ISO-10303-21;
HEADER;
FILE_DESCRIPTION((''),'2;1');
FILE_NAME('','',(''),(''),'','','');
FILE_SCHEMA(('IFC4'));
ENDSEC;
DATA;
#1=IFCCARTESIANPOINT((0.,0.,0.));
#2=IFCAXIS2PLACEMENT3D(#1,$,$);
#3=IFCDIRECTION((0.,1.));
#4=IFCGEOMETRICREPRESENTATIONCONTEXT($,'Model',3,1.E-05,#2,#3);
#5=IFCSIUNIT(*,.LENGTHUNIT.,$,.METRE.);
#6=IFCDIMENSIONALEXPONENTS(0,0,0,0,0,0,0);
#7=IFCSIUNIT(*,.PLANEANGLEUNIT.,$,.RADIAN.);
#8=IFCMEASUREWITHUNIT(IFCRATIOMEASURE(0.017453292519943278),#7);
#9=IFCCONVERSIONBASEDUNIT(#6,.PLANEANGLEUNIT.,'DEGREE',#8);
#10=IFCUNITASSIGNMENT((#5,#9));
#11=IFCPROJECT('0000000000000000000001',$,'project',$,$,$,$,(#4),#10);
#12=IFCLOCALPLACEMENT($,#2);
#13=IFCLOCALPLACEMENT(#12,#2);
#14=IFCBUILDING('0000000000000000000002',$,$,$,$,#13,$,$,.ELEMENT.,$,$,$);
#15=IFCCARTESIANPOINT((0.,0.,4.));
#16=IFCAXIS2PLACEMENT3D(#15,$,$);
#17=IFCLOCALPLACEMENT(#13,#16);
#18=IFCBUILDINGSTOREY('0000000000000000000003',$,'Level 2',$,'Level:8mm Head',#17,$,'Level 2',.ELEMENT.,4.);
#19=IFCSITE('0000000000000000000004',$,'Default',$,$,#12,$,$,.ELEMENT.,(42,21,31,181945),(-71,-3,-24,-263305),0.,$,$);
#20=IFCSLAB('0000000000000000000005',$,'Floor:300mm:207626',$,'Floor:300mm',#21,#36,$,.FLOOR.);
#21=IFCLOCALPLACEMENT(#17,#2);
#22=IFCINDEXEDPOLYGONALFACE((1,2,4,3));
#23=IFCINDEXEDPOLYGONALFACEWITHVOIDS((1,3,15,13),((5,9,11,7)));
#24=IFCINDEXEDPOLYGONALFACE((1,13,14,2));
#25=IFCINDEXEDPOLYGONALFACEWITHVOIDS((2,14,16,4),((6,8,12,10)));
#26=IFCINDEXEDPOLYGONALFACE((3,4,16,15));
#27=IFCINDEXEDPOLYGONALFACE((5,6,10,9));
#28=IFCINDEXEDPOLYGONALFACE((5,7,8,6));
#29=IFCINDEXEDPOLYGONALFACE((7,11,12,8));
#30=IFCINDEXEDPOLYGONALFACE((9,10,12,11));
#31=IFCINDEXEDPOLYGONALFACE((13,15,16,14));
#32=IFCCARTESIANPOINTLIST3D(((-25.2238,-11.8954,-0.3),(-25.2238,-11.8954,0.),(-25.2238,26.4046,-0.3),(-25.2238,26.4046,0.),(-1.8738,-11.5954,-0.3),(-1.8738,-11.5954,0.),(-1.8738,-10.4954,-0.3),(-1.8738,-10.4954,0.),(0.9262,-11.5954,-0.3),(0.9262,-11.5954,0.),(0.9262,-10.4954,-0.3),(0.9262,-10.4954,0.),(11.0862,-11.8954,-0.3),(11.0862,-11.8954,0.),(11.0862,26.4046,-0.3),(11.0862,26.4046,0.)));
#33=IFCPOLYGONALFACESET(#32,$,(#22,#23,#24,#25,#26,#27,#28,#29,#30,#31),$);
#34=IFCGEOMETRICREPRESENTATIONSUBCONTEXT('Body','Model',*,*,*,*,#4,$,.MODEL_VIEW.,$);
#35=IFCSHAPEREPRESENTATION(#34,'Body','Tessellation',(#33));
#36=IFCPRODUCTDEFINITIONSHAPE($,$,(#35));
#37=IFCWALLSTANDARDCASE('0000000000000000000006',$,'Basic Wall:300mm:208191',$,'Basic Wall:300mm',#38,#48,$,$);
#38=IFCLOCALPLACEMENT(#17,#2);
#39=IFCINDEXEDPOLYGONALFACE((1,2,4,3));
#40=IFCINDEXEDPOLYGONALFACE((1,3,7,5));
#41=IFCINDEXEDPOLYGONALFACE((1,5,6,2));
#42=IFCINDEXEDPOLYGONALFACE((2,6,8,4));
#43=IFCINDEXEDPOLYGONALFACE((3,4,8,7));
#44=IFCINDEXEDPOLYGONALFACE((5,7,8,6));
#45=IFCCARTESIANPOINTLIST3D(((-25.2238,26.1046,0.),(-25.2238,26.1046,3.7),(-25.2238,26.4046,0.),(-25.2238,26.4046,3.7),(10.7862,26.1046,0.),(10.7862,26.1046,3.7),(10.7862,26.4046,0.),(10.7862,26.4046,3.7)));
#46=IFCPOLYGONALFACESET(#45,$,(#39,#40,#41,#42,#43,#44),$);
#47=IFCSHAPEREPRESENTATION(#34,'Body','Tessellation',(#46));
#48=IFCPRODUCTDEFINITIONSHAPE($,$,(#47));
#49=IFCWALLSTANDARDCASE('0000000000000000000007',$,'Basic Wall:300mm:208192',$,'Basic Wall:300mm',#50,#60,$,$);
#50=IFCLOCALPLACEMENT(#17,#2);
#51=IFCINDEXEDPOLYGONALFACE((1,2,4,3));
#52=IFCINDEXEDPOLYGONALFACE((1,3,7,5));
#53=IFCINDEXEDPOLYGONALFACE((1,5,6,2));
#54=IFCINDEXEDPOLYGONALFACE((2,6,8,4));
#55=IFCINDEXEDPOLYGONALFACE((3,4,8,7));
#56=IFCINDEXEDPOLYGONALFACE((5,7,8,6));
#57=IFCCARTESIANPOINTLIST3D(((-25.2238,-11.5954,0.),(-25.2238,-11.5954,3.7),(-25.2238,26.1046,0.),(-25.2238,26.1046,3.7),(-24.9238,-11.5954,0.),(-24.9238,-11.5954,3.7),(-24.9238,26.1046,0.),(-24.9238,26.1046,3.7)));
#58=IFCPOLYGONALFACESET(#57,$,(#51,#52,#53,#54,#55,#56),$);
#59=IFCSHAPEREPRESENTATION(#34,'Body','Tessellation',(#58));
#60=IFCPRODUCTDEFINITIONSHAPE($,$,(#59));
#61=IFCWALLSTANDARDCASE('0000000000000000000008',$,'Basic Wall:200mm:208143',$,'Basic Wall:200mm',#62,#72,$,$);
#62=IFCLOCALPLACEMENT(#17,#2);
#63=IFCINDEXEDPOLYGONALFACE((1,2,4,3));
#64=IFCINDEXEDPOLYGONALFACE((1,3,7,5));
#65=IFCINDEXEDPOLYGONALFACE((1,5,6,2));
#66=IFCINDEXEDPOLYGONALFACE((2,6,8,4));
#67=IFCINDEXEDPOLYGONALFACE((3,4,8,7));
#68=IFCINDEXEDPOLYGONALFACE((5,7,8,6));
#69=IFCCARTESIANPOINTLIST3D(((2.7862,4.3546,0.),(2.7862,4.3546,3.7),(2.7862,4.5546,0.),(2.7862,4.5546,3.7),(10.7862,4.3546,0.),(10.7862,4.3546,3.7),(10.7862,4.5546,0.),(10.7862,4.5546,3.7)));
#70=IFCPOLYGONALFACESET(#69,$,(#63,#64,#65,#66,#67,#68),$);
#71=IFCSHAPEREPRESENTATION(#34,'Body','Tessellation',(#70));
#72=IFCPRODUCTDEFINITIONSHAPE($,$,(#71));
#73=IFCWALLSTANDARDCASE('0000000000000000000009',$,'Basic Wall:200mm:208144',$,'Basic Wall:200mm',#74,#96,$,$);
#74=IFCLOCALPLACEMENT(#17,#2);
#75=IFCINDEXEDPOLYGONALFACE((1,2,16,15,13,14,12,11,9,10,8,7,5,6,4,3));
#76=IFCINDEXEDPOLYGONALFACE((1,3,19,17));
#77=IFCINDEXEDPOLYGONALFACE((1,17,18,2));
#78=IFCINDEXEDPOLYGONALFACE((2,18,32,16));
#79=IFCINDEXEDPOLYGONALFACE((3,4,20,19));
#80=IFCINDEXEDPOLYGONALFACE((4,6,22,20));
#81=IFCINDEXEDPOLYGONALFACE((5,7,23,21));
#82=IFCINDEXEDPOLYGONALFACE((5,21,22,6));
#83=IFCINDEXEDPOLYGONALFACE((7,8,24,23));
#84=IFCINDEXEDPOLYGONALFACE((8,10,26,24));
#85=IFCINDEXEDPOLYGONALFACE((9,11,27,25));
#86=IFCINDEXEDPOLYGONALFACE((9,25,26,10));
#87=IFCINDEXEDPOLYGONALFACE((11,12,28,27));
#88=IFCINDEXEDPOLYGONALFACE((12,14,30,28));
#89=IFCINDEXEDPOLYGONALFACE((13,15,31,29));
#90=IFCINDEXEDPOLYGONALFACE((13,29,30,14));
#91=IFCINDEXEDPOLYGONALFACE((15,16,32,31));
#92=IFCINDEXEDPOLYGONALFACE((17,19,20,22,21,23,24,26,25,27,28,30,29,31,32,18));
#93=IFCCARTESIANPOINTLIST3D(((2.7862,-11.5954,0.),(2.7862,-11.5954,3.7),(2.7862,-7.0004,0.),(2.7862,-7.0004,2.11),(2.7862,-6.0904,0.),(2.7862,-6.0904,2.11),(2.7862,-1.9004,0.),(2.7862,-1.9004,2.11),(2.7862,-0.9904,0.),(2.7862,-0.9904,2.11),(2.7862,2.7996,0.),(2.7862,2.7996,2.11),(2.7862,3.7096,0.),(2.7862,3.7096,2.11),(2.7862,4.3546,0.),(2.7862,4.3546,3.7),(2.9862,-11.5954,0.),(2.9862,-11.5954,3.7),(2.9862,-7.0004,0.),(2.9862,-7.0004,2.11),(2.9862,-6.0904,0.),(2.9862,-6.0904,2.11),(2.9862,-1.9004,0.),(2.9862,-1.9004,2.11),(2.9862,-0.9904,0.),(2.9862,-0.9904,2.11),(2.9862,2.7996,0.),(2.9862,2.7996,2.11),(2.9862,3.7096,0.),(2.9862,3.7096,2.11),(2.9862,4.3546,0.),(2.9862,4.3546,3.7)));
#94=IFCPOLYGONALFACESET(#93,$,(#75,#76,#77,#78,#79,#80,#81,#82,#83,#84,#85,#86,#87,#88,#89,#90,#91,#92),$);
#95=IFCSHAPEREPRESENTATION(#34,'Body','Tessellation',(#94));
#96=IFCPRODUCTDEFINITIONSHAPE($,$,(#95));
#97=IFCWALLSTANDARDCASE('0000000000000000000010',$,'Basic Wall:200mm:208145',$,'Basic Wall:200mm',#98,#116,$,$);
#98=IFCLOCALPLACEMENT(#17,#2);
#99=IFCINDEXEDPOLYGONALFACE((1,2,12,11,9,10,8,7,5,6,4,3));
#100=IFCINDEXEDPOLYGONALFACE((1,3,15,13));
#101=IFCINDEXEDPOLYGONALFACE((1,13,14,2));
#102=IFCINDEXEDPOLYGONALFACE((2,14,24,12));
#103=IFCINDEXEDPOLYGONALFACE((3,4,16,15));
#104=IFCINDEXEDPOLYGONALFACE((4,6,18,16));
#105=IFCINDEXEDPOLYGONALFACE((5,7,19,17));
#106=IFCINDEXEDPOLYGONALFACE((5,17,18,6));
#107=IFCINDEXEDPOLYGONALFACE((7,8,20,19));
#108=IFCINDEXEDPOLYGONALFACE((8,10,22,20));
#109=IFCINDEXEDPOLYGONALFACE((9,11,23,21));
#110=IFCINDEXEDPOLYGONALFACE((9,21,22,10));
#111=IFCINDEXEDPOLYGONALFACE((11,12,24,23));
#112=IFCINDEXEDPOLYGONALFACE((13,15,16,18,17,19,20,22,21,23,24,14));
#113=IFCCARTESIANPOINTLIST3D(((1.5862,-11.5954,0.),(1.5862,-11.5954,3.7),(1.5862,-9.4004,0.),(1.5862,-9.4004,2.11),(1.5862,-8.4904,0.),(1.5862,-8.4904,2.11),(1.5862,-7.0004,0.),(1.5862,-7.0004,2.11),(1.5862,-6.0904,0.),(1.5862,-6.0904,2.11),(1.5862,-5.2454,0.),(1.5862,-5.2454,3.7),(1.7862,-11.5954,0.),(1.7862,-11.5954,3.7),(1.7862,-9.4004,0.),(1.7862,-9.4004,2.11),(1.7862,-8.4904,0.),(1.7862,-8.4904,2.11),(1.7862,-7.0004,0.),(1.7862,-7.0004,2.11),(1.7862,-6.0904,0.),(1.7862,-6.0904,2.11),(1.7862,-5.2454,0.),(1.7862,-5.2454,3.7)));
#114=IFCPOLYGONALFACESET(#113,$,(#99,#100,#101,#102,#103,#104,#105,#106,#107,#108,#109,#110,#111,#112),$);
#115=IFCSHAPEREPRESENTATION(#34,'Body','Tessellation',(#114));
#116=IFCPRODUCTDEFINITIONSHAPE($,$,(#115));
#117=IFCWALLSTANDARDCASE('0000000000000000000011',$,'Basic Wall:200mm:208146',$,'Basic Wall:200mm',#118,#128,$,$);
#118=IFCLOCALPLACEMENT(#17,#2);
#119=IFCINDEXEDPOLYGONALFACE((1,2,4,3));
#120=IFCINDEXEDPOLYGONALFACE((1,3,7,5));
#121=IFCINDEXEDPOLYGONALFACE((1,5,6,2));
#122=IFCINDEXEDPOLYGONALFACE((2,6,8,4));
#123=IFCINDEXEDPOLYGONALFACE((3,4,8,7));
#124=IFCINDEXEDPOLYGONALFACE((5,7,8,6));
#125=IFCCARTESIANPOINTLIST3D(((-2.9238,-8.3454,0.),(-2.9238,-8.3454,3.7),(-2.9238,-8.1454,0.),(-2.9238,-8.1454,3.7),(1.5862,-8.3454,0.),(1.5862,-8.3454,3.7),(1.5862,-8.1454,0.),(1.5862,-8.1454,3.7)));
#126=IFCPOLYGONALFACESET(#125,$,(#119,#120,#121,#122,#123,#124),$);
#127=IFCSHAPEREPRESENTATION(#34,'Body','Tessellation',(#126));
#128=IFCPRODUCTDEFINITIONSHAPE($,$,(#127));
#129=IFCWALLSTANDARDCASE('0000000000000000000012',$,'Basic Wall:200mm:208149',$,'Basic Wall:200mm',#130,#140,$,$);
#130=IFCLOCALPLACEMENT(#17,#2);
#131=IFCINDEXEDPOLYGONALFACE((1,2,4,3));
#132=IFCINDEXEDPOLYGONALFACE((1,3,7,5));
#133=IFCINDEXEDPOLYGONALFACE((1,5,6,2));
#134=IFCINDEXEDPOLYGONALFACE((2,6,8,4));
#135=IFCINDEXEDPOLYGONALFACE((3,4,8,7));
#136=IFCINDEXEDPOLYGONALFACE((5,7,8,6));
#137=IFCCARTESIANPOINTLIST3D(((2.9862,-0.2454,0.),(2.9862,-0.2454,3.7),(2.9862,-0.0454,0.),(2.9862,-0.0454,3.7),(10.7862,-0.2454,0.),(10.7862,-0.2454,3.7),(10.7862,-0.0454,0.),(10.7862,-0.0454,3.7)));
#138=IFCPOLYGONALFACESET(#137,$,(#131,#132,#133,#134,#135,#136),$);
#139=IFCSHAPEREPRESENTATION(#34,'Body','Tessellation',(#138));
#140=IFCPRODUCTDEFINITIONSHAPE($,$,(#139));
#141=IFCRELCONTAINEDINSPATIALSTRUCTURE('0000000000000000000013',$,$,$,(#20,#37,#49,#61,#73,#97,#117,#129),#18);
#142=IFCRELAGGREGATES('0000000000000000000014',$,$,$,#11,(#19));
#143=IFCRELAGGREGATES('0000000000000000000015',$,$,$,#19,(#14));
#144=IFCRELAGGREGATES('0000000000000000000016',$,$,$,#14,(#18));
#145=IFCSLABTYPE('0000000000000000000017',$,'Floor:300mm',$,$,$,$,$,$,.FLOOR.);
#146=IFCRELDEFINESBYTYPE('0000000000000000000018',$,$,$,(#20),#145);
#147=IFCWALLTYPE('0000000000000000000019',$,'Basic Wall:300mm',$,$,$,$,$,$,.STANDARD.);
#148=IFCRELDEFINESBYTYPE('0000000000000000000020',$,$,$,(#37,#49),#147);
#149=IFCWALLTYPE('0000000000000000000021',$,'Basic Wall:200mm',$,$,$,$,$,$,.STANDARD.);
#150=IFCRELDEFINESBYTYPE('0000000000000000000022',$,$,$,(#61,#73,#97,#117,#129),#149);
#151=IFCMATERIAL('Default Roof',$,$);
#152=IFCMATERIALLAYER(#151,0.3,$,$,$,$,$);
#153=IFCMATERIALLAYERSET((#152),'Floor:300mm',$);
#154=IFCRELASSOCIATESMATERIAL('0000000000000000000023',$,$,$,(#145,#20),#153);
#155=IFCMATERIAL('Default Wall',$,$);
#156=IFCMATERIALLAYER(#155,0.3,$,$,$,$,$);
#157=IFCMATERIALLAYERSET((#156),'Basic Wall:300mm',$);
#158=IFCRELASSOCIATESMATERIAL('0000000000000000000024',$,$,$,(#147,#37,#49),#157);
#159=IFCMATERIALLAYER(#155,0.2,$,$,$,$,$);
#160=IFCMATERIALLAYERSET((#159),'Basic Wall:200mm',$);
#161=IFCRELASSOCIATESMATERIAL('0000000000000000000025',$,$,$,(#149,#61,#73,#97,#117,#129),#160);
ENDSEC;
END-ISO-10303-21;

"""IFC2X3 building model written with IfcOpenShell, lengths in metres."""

from ifc_helpers import new_model, entity, si_unit, converted_unit, direction, frame, frame_2d, origin, origin_2d_with_axis, place, context, subcontext, project, spatial, polyline, rectangle, extrude, clip, bounded_halfspace, material, layer, layer_set, layer_usage, type_object, element, save


model = new_model("IFC2X3")

# Units and contexts
model_context = context("Model", 3, precision=1e-05, world=origin(), true_north=direction((0.0, 1.0)))
body_context = subcontext(model_context, "Body", "Model", "MODEL_VIEW")
ifc_project = project(units=[si_unit("LENGTHUNIT", "METRE"), converted_unit("PLANEANGLEUNIT", "DEGREE", entity("IfcRatioMeasure", 0.017453292519943278), si_unit("PLANEANGLEUNIT", "RADIAN"), dimensions=[0, 0, 0, 0, 0, 0, 0])], contexts=[model_context])

# Site, building, storey
site_placement = place(None, origin())
site = spatial("IfcSite", under=ifc_project, at=site_placement, Name="Default", CompositionType="ELEMENT", RefLatitude=(42, 21, 31, 181945), RefLongitude=(-71, -3, -24, -263305), RefElevation=0.0)
building_placement = place(site_placement, origin())
building = spatial("IfcBuilding", under=site, at=building_placement, CompositionType="ELEMENT")
storey_placement = place(building_placement, frame((0.0, 0.0, 4.0)))
storey = spatial("IfcBuildingStorey", under=building, at=storey_placement, Name="Level 2", ObjectType="Level:8mm Head", LongName="Level 2", CompositionType="ELEMENT", Elevation=4.0)

# Slab, opening
ifc_material_1 = material(Name="Default Roof")
ifc_layer_1 = layer(ifc_material_1, 0.3)
ifc_layer_set_1 = layer_set([ifc_layer_1], Name="Floor:300mm")
ifc_layer_usage_1 = layer_usage(ifc_layer_set_1, "AXIS3", "POSITIVE", 0.0)
slab_type = type_object("IfcSlabType", Name="Floor:300mm", PredefinedType="FLOOR", material=ifc_layer_set_1)
slab_placement = place(storey_placement, frame((-25.2238, -11.8954, -0.3)))
slab = element("IfcSlab", 1, at=slab_placement, inside=storey, type_object=slab_type, material=ifc_layer_usage_1, Name="Floor:300mm:207626", ObjectType="Floor:300mm", PredefinedType="FLOOR", context=body_context, shape_type="SweptSolid", body=[
    extrude(rectangle(XDim=38.3, YDim=36.31, at=frame_2d((0.0, 0.0), x_axis=(0.0, -1.0))), frame((18.155, 19.15, 0.3), z_axis=(0.0, 0.0, -1.0), x_axis=(-1.0, 0.0, 0.0)), (0.0, 0.0, 1.0), 0.3),
])
opening_1_placement = place(slab_placement, frame((24.75, 0.85, 0.3)))
element("IfcOpeningElement", 2, at=opening_1_placement, cuts=slab, ObjectType="Opening", context=body_context, shape_type="SweptSolid", body=[
    extrude(rectangle(XDim=1.1, YDim=2.8, at=origin_2d_with_axis()), frame((0.0, 0.0, 0.0), z_axis=(0.0, 0.0, 1.0), x_axis=(0.0, -1.0, 0.0)), (0.0, 0.0, -1.0), 0.3),
])

# Walls
ifc_material_2 = material(Name="Default Wall")
ifc_layer_2 = layer(ifc_material_2, 0.3)
ifc_layer_set_2 = layer_set([ifc_layer_2], Name="Basic Wall:300mm")
wall_type_1 = type_object("IfcWallType", Name="Basic Wall:300mm", PredefinedType="STANDARD", material=ifc_layer_set_2)
ifc_layer_usage_2 = layer_usage(ifc_layer_set_2, "AXIS2", "NEGATIVE", 0.15)
wall_1_placement = place(storey_placement, frame((-25.2238, 26.2546, 0.0)))
element("IfcWallStandardCase", 3, at=wall_1_placement, inside=storey, type_object=wall_type_1, material=ifc_layer_usage_2, Name="Basic Wall:300mm:208191", ObjectType="Basic Wall:300mm", context=body_context, shape_type="Clipping", body=[
    clip(extrude(rectangle(XDim=36.01, YDim=0.3, at=frame_2d((18.005, 0.0), x_axis=(-1.0, 0.0))), origin(), (0.0, 0.0, 1.0), 3.7), bounded_halfspace(frame((0.0, -0.15, 3.7), z_axis=(0.0, 0.0, -1.0), x_axis=(0.0, -1.0, 0.0)), True, frame((0.0, -0.15, 3.7), z_axis=(0.0, 0.0, -1.0), x_axis=(0.0, -1.0, 0.0)), polyline([(0.0, 0.0), (-0.3, 0.0), (-0.3, -36.01), (0.0, -36.01), (0.0, -0.3), (0.0, 0.0)]))),
])
ifc_layer_usage_3 = layer_usage(ifc_layer_set_2, "AXIS2", "NEGATIVE", 0.15)
wall_2_placement = place(storey_placement, frame((-25.0738, -11.5954, 0.0), z_axis=(0.0, 0.0, 1.0), x_axis=(0.0, 1.0, 0.0)))
element("IfcWallStandardCase", 4, at=wall_2_placement, inside=storey, type_object=wall_type_1, material=ifc_layer_usage_3, Name="Basic Wall:300mm:208192", ObjectType="Basic Wall:300mm", context=body_context, shape_type="Clipping", body=[
    clip(extrude(rectangle(XDim=37.7, YDim=0.3, at=frame_2d((18.85, 0.0), x_axis=(-1.0, 0.0))), origin(), (0.0, 0.0, 1.0), 3.7), bounded_halfspace(frame((0.0, -0.15, 3.7), z_axis=(0.0, 0.0, -1.0), x_axis=(-1.0, 0.0, 0.0)), True, frame((0.0, -0.15, 3.7), z_axis=(0.0, 0.0, -1.0), x_axis=(-1.0, 0.0, 0.0)), polyline([(0.0, 0.0), (0.0, 0.3), (-37.7, 0.3), (-37.7, 0.0), (-6.35, 0.0), (-6.15, 0.0), (0.0, 0.0)]))),
])
ifc_layer_3 = layer(ifc_material_2, 0.2)
ifc_layer_set_3 = layer_set([ifc_layer_3], Name="Basic Wall:200mm")
ifc_layer_usage_4 = layer_usage(ifc_layer_set_3, "AXIS2", "NEGATIVE", 0.1)
wall_type_2 = type_object("IfcWallType", Name="Basic Wall:200mm", PredefinedType="STANDARD", material=ifc_layer_set_3)
wall_3_placement = place(storey_placement, frame((10.7862, 4.4546, 0.0), z_axis=(0.0, 0.0, 1.0), x_axis=(-1.0, 0.0, 0.0)))
element("IfcWallStandardCase", 5, at=wall_3_placement, inside=storey, type_object=wall_type_2, material=ifc_layer_usage_4, Name="Basic Wall:200mm:208143", ObjectType="Basic Wall:200mm", context=body_context, shape_type="Clipping", body=[
    clip(extrude(rectangle(XDim=8.0, YDim=0.2, at=frame_2d((4.0, 0.0), x_axis=(-1.0, 0.0))), origin(), (0.0, 0.0, 1.0), 3.7), bounded_halfspace(frame((0.0, -0.1, 3.7), z_axis=(0.0, 0.0, -1.0), x_axis=(0.0, 1.0, 0.0)), True, frame((0.0, -0.1, 3.7), z_axis=(0.0, 0.0, -1.0), x_axis=(0.0, 1.0, 0.0)), polyline([(0.0, 0.0), (0.2, 0.0), (0.2, 7.8), (0.2, 8.0), (0.0, 8.0), (0.0, 0.0)]))),
])

# Walls, openings
ifc_layer_usage_5 = layer_usage(ifc_layer_set_3, "AXIS2", "NEGATIVE", 0.1)
wall_4_placement = place(storey_placement, frame((2.8862, 4.3546, 0.0), z_axis=(0.0, 0.0, 1.0), x_axis=(0.0, -1.0, 0.0)))
wall_4 = element("IfcWallStandardCase", 6, at=wall_4_placement, inside=storey, type_object=wall_type_2, material=ifc_layer_usage_5, Name="Basic Wall:200mm:208144", ObjectType="Basic Wall:200mm", context=body_context, shape_type="Clipping", body=[
    clip(extrude(rectangle(XDim=15.95, YDim=0.2, at=frame_2d((7.975, 0.0), x_axis=(-1.0, 0.0))), origin(), (0.0, 0.0, 1.0), 3.7), bounded_halfspace(frame((0.0, -0.1, 3.7), z_axis=(0.0, 0.0, -1.0), x_axis=(1.0, 0.0, 0.0)), True, frame((0.0, -0.1, 3.7), z_axis=(0.0, 0.0, -1.0), x_axis=(1.0, 0.0, 0.0)), polyline([(0.0, 0.0), (0.0, -0.2), (4.4, -0.2), (4.6, -0.2), (9.8, -0.2), (10.0, -0.2), (15.95, -0.2), (15.95, 0.0), (0.0, 0.0)]))),
])
opening_2_placement = place(wall_4_placement, frame((0.645, -0.1, 0.0)))
element("IfcOpeningElement", 7, at=opening_2_placement, cuts=wall_4, ObjectType="Opening", context=body_context, shape_type="SweptSolid", body=[
    extrude(rectangle(XDim=2.11, YDim=0.91, at=frame_2d((1.055, 0.455), x_axis=(1.0, 0.0))), frame((0.0, 0.0, 0.0), z_axis=(0.0, 1.0, 0.0), x_axis=(0.0, 0.0, 1.0)), (0.0, 0.0, 1.0), 0.2),
])
opening_3_placement = place(wall_4_placement, frame((5.345, -0.1, 0.0)))
element("IfcOpeningElement", 8, at=opening_3_placement, cuts=wall_4, ObjectType="Opening", context=body_context, shape_type="SweptSolid", body=[
    extrude(rectangle(XDim=2.11, YDim=0.91, at=frame_2d((1.055, 0.455), x_axis=(1.0, 0.0))), frame((0.0, 0.0, 0.0), z_axis=(0.0, 1.0, 0.0), x_axis=(0.0, 0.0, 1.0)), (0.0, 0.0, 1.0), 0.2),
])
opening_4_placement = place(wall_4_placement, frame((10.445, -0.1, 0.0)))
element("IfcOpeningElement", 9, at=opening_4_placement, cuts=wall_4, ObjectType="Opening", context=body_context, shape_type="SweptSolid", body=[
    extrude(rectangle(XDim=2.11, YDim=0.91, at=frame_2d((1.055, 0.455), x_axis=(1.0, 0.0))), frame((0.0, 0.0, 0.0), z_axis=(0.0, 1.0, 0.0), x_axis=(0.0, 0.0, 1.0)), (0.0, 0.0, 1.0), 0.2),
])
ifc_layer_usage_6 = layer_usage(ifc_layer_set_3, "AXIS2", "NEGATIVE", 0.1)
wall_5_placement = place(storey_placement, frame((1.6862, -11.5954, 0.0), z_axis=(0.0, 0.0, 1.0), x_axis=(0.0, 1.0, 0.0)))
wall_5 = element("IfcWallStandardCase", 10, at=wall_5_placement, inside=storey, type_object=wall_type_2, material=ifc_layer_usage_6, Name="Basic Wall:200mm:208145", ObjectType="Basic Wall:200mm", context=body_context, shape_type="Clipping", body=[
    clip(extrude(rectangle(XDim=6.35, YDim=0.2, at=frame_2d((3.175, 0.0), x_axis=(-1.0, 0.0))), origin(), (0.0, 0.0, 1.0), 3.7), bounded_halfspace(frame((0.0, -0.1, 3.7), z_axis=(0.0, 0.0, -1.0), x_axis=(-1.0, 0.0, 0.0)), True, frame((0.0, -0.1, 3.7), z_axis=(0.0, 0.0, -1.0), x_axis=(-1.0, 0.0, 0.0)), polyline([(0.0, 0.0), (0.0, 0.2), (-3.25, 0.2), (-3.45, 0.2), (-6.15, 0.2), (-6.35, 0.2), (-6.35, 0.0), (0.0, 0.0)]))),
])
opening_5_placement = place(wall_5_placement, frame((3.105, 0.1, 0.0)))
element("IfcOpeningElement", 11, at=opening_5_placement, cuts=wall_5, ObjectType="Opening", context=body_context, shape_type="SweptSolid", body=[
    extrude(rectangle(XDim=2.11, YDim=0.91, at=frame_2d((1.055, 0.455), x_axis=(1.0, 0.0))), frame((0.0, 0.0, 0.0), z_axis=(0.0, -1.0, 0.0), x_axis=(0.0, 0.0, 1.0)), (0.0, 0.0, 1.0), 0.2),
])
opening_6_placement = place(wall_5_placement, frame((4.595, -0.1, 0.0)))
element("IfcOpeningElement", 12, at=opening_6_placement, cuts=wall_5, ObjectType="Opening", context=body_context, shape_type="SweptSolid", body=[
    extrude(rectangle(XDim=2.11, YDim=0.91, at=frame_2d((1.055, 0.455), x_axis=(1.0, 0.0))), frame((0.0, 0.0, 0.0), z_axis=(0.0, 1.0, 0.0), x_axis=(0.0, 0.0, 1.0)), (0.0, 0.0, 1.0), 0.2),
])

# Walls
ifc_layer_usage_7 = layer_usage(ifc_layer_set_3, "AXIS2", "NEGATIVE", 0.1)
wall_6_placement = place(storey_placement, frame((1.5862, -8.2454, 0.0), z_axis=(0.0, 0.0, 1.0), x_axis=(-1.0, 0.0, 0.0)))
element("IfcWallStandardCase", 13, at=wall_6_placement, inside=storey, type_object=wall_type_2, material=ifc_layer_usage_7, Name="Basic Wall:200mm:208146", ObjectType="Basic Wall:200mm", context=body_context, shape_type="Clipping", body=[
    clip(extrude(rectangle(XDim=4.51, YDim=0.2, at=frame_2d((2.255, 0.0), x_axis=(-1.0, 0.0))), origin(), (0.0, 0.0, 1.0), 3.7), bounded_halfspace(frame((0.0, -0.1, 3.7), z_axis=(0.0, 0.0, -1.0), x_axis=(0.0, 1.0, 0.0)), True, frame((0.0, -0.1, 3.7), z_axis=(0.0, 0.0, -1.0), x_axis=(0.0, 1.0, 0.0)), polyline([(0.0, 0.0), (0.2, 0.0), (0.2, 4.51), (0.0, 4.51), (0.0, 0.0)]))),
])
ifc_layer_usage_8 = layer_usage(ifc_layer_set_3, "AXIS2", "NEGATIVE", 0.1)
wall_7_placement = place(storey_placement, frame((2.9862, -0.1454, 0.0)))
element("IfcWallStandardCase", 14, at=wall_7_placement, inside=storey, type_object=wall_type_2, material=ifc_layer_usage_8, Name="Basic Wall:200mm:208149", ObjectType="Basic Wall:200mm", context=body_context, shape_type="Clipping", body=[
    clip(extrude(rectangle(XDim=7.8, YDim=0.2, at=frame_2d((3.9, 0.0), x_axis=(-1.0, 0.0))), origin(), (0.0, 0.0, 1.0), 3.7), bounded_halfspace(frame((0.0, -0.1, 3.7), z_axis=(0.0, 0.0, -1.0), x_axis=(0.0, -1.0, 0.0)), True, frame((0.0, -0.1, 3.7), z_axis=(0.0, 0.0, -1.0), x_axis=(0.0, -1.0, 0.0)), polyline([(0.0, 0.0), (-0.2, 0.0), (-0.2, -7.8), (0.0, -7.8), (0.0, 0.0)]))),
])

save(model, "model.ifc")
